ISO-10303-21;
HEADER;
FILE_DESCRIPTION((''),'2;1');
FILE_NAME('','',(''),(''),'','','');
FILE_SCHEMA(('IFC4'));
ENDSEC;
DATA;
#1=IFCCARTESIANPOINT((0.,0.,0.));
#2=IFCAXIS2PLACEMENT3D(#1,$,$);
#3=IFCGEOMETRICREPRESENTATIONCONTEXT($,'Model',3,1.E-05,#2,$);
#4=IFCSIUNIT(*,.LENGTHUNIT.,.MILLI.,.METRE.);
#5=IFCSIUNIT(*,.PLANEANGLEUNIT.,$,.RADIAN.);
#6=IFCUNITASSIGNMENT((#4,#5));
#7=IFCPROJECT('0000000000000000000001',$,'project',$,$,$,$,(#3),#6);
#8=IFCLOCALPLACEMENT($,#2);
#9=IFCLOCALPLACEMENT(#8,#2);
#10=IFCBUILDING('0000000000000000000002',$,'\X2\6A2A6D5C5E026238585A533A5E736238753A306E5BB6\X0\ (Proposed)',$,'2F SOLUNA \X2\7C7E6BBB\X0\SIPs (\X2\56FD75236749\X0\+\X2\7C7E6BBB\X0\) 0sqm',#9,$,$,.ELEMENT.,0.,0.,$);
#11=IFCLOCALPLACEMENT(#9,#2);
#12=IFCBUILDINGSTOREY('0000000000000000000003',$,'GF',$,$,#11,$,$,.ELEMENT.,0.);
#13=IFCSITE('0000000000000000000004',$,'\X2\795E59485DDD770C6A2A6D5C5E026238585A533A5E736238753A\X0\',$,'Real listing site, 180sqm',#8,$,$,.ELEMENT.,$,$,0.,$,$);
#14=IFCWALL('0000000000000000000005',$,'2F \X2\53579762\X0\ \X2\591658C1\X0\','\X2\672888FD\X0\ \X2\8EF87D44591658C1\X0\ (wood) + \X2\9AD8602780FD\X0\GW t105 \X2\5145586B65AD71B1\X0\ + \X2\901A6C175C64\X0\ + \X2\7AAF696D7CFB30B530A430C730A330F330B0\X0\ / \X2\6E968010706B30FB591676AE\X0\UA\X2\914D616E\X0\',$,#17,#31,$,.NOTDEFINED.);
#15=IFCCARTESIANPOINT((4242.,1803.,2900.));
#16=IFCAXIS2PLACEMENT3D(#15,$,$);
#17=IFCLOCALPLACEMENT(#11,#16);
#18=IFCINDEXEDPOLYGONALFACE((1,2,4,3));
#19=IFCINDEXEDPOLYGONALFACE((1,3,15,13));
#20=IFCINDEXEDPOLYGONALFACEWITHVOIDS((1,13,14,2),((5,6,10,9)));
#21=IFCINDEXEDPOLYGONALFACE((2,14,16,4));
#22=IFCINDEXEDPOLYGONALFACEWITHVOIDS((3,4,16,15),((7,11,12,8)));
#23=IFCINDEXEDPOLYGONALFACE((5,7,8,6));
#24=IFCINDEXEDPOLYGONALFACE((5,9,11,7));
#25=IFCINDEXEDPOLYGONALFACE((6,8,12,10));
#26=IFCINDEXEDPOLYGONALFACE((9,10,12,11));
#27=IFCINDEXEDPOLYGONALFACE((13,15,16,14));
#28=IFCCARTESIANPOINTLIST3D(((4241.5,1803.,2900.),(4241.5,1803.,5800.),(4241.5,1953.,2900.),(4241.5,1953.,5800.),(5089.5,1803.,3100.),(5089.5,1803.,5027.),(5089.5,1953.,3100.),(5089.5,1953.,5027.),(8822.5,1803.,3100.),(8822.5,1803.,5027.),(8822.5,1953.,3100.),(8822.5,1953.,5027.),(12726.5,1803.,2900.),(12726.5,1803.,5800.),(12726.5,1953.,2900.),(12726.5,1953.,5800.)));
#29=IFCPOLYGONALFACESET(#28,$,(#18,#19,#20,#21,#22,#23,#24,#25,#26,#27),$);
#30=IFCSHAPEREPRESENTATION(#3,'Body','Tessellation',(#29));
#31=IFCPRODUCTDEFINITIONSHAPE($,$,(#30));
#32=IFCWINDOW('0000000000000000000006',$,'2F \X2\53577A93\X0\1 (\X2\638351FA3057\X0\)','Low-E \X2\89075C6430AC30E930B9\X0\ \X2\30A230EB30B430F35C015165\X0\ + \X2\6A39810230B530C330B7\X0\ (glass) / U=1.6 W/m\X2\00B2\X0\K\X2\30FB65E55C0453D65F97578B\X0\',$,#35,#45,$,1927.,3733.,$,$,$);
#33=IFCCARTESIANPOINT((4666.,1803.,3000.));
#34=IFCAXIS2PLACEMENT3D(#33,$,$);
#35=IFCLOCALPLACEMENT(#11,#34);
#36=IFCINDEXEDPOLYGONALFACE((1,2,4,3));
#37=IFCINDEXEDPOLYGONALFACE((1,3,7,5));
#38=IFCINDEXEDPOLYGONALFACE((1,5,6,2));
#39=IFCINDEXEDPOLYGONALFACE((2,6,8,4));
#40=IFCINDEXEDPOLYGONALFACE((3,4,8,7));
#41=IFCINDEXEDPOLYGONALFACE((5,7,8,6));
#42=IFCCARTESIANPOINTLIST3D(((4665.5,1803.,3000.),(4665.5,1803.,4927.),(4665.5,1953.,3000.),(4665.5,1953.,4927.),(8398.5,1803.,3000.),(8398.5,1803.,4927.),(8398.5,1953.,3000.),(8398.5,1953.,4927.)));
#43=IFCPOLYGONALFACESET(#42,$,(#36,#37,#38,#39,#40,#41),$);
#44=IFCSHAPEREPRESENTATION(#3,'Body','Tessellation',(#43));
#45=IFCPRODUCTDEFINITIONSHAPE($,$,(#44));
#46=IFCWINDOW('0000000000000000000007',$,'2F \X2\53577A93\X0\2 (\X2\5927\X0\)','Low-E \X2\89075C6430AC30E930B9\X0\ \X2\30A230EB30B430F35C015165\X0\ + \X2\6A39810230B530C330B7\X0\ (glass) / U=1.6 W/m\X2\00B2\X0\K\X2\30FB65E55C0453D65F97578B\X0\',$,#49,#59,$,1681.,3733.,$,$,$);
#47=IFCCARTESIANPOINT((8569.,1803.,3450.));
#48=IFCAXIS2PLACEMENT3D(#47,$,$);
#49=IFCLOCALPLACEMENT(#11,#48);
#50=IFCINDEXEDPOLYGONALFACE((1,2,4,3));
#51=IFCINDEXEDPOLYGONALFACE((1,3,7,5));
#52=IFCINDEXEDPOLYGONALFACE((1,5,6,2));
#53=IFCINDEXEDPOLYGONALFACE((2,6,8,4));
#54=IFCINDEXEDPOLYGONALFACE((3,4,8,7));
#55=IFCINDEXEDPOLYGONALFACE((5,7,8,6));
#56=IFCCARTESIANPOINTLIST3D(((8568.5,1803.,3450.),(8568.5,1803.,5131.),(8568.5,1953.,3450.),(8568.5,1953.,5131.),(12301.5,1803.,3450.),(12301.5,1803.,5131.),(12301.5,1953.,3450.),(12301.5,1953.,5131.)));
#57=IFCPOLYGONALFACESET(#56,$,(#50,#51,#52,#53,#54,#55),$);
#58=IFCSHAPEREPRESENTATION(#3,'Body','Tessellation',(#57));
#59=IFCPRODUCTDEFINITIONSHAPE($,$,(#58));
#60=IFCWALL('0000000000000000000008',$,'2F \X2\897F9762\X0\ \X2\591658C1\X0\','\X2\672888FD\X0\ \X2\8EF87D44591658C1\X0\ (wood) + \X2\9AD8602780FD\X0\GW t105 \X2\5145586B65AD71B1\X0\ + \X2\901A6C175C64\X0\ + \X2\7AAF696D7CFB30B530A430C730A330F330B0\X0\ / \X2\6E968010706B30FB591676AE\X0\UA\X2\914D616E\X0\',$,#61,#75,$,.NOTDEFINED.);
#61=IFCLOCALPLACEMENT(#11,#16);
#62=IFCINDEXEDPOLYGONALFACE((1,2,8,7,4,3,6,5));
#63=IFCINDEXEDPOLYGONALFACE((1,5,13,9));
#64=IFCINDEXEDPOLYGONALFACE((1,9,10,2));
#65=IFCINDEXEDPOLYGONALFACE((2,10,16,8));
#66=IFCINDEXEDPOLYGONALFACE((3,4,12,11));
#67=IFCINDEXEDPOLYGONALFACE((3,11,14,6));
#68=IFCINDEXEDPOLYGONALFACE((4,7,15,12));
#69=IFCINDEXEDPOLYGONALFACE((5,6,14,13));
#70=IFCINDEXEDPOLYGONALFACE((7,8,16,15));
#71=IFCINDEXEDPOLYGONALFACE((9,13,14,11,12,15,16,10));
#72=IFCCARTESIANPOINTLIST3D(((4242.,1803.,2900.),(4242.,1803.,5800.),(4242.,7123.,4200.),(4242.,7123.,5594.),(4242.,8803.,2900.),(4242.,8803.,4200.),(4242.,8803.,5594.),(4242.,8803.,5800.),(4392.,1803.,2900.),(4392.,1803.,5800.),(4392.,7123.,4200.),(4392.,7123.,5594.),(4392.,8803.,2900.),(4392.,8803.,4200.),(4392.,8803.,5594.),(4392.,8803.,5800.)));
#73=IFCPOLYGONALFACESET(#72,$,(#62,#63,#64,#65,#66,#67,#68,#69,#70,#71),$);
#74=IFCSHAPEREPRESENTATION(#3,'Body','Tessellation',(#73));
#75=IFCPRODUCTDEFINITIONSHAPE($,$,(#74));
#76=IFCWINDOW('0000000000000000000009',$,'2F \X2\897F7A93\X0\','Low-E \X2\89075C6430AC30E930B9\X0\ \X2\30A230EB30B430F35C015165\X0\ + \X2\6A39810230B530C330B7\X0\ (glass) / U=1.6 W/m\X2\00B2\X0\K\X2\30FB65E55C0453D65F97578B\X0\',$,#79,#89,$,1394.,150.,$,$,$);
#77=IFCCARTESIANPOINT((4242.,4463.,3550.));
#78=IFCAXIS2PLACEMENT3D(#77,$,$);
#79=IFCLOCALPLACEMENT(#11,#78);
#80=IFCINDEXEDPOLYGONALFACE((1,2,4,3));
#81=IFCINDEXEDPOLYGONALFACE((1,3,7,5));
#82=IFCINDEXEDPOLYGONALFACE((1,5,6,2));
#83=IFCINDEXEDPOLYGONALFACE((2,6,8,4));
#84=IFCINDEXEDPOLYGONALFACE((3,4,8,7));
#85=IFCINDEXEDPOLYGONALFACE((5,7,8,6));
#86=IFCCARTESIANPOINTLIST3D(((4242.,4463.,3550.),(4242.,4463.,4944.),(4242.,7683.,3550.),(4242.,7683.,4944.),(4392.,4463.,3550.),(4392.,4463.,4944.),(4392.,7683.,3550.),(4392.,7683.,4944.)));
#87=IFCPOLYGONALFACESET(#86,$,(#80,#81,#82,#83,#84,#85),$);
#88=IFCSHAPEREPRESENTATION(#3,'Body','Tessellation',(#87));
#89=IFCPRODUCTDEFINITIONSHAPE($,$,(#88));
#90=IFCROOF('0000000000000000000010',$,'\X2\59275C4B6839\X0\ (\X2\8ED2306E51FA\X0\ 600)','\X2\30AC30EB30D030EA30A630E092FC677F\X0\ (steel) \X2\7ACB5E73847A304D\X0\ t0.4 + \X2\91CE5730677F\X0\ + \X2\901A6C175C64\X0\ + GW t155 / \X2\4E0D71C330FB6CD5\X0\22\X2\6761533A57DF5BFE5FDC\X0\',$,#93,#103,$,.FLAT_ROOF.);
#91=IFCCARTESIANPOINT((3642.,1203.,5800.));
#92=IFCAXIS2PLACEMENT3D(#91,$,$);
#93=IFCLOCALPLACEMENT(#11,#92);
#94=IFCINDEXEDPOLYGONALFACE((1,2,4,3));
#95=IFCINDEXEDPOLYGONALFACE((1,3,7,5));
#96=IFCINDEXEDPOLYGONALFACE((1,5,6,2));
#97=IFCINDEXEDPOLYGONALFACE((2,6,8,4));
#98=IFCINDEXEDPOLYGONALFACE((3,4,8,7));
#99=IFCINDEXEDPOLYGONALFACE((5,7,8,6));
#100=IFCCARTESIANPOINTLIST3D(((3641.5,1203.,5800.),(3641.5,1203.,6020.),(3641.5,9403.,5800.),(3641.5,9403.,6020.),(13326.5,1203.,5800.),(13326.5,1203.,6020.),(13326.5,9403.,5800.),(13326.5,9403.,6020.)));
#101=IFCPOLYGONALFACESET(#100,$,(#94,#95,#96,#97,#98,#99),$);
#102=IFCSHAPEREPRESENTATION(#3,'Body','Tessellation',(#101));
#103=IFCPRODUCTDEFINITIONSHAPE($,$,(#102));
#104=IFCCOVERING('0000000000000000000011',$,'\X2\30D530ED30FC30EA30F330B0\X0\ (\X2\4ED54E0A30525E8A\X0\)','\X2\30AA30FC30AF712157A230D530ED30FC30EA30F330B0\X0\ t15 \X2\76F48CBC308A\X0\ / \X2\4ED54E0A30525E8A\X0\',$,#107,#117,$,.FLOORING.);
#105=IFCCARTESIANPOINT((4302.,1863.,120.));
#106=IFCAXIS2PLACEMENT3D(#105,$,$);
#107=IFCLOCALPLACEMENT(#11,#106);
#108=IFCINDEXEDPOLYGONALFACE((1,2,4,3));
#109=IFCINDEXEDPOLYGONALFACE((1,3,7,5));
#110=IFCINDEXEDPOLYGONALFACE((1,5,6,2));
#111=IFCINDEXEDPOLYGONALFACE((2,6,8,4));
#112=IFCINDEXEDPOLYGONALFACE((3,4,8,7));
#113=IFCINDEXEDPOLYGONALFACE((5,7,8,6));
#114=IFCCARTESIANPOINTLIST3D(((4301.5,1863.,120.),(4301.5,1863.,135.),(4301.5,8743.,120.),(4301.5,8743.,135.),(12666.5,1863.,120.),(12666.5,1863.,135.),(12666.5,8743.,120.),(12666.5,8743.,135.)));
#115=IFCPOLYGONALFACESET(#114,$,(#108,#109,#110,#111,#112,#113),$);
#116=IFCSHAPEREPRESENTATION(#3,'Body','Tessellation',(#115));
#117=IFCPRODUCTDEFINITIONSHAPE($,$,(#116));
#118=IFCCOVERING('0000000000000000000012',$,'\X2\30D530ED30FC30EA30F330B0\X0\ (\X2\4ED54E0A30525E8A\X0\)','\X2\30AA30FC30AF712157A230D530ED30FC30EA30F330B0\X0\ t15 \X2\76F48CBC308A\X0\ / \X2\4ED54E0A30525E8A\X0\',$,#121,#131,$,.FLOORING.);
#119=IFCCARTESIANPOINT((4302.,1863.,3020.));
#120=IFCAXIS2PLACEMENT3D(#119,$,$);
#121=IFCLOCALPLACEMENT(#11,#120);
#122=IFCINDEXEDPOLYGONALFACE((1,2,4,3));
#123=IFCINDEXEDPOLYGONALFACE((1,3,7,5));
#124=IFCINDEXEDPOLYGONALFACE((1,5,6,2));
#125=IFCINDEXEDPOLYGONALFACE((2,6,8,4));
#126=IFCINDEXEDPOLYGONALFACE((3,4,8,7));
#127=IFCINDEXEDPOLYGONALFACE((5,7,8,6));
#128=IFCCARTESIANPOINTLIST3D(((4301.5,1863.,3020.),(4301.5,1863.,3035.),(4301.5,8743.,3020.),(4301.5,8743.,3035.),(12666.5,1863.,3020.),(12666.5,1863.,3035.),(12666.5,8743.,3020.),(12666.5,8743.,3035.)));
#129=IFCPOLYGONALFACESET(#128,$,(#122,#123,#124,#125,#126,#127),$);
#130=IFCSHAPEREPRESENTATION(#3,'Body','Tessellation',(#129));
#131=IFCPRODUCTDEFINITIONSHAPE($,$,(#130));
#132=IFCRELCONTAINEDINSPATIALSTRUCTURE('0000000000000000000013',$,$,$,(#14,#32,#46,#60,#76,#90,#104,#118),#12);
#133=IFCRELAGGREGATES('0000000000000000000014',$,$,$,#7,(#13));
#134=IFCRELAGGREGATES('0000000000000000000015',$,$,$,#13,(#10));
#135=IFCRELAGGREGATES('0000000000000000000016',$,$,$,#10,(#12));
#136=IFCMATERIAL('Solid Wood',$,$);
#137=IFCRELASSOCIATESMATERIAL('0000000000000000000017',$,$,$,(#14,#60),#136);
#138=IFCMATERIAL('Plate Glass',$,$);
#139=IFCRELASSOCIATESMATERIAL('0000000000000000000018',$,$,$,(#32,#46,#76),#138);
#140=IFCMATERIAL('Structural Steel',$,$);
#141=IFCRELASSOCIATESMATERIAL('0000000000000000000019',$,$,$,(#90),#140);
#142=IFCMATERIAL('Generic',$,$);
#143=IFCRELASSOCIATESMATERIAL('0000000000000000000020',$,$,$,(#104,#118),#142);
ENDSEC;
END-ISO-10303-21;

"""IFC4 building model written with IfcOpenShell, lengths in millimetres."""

from ifc_helpers import new_model, si_unit, frame, frame_2d, origin, place, context, project, spatial, rectangle, extrude, material, element, fill, save


model = new_model("IFC4")

# Units and contexts
model_context = context("Model", 3, precision=1e-05, world=origin())
ifc_project = project(units=[si_unit("LENGTHUNIT", "METRE", prefix="MILLI"), si_unit("PLANEANGLEUNIT", "RADIAN")], contexts=[model_context])

# Site, building, storey
site_placement = place(None, origin())
site = spatial("IfcSite", under=ifc_project, at=site_placement, Name="神奈川県横浜市戸塚区平戸町", ObjectType="Real listing site, 180sqm", CompositionType="ELEMENT", RefElevation=0.0)
building_placement = place(site_placement, origin())
building = spatial("IfcBuilding", under=site, at=building_placement, Name="横浜市戸塚区平戸町の家 (Proposed)", ObjectType="2F SOLUNA 籾殻SIPs (国産杉+籾殻) 0sqm", CompositionType="ELEMENT", ElevationOfRefHeight=0.0, ElevationOfTerrain=0.0)
storey_placement = place(building_placement, origin())
storey = spatial("IfcBuildingStorey", under=building, at=storey_placement, Name="GF", CompositionType="ELEMENT", Elevation=0.0)

# Shared definitions
ifc_material_1 = material(Name="Solid Wood")

# Shared definitions
ifc_material_2 = material(Name="Plate Glass")

# Wall, openings, windows
wall_1_placement = place(storey_placement, frame((4242.0, 1803.0, 2900.0)))
wall_1 = element("IfcWall", 1, at=wall_1_placement, inside=storey, material=ifc_material_1, Name="2F 南面 外壁", Description="木製 軸組外壁 (wood) + 高性能GW t105 充填断熱 + 通気層 + 窯業系サイディング / 準耐火・外皮UA配慮", PredefinedType="NOTDEFINED", context=model_context, shape_type="SweptSolid", body=[
    extrude(rectangle(XDim=8485.0, YDim=150.0, at=frame_2d((4242.0, 75.0))), frame((4242.0, 1803.0, 2900.0)), (0.0, 0.0, 1.0), 2900.0),
])
opening_1_placement = place(storey_placement, frame((4666.0, 1803.0, 3000.0)))
opening_1 = element("IfcOpeningElement", 2, at=opening_1_placement, cuts=wall_1, PredefinedType="NOTDEFINED", context=model_context, shape_type="SweptSolid", body=[
    extrude(rectangle(XDim=3733.0, YDim=150.0, at=frame_2d((1866.0, 75.0))), frame((4666.0, 1803.0, 3000.0)), (0.0, 0.0, 1.0), 1927.0),
])
opening_2_placement = place(storey_placement, frame((8569.0, 1803.0, 3450.0)))
opening_2 = element("IfcOpeningElement", 3, at=opening_2_placement, cuts=wall_1, PredefinedType="NOTDEFINED", context=model_context, shape_type="SweptSolid", body=[
    extrude(rectangle(XDim=3733.0, YDim=150.0, at=frame_2d((1866.0, 75.0))), frame((8569.0, 1803.0, 3450.0)), (0.0, 0.0, 1.0), 1681.0),
])
window_1_placement = place(storey_placement, frame((4666.0, 1803.0, 3000.0)))
window_1 = element("IfcWindow", 4, at=window_1_placement, inside=storey, material=ifc_material_2, Name="2F 南窓1 (掃出し)", Description="Low-E 複層ガラス アルゴン封入 + 樹脂サッシ (glass) / U=1.6 W/m²K・日射取得型", OverallHeight=1927.0, OverallWidth=3733.0, context=model_context, shape_type="SweptSolid", body=[
    extrude(rectangle(XDim=3733.0, YDim=150.0, at=frame_2d((1866.0, 75.0))), frame((4666.0, 1803.0, 3000.0)), (0.0, 0.0, 1.0), 1927.0),
])
fill(opening_1, window_1)
window_2_placement = place(storey_placement, frame((8569.0, 1803.0, 3450.0)))
window_2 = element("IfcWindow", 5, at=window_2_placement, inside=storey, material=ifc_material_2, Name="2F 南窓2 (大)", Description="Low-E 複層ガラス アルゴン封入 + 樹脂サッシ (glass) / U=1.6 W/m²K・日射取得型", OverallHeight=1681.0, OverallWidth=3733.0, context=model_context, shape_type="SweptSolid", body=[
    extrude(rectangle(XDim=3733.0, YDim=150.0, at=frame_2d((1866.0, 75.0))), frame((8569.0, 1803.0, 3450.0)), (0.0, 0.0, 1.0), 1681.0),
])
fill(opening_2, window_2)

# Wall, opening, window
wall_2_placement = place(storey_placement, frame((4242.0, 1803.0, 2900.0)))
wall_2 = element("IfcWall", 6, at=wall_2_placement, inside=storey, material=ifc_material_1, Name="2F 西面 外壁", Description="木製 軸組外壁 (wood) + 高性能GW t105 充填断熱 + 通気層 + 窯業系サイディング / 準耐火・外皮UA配慮", PredefinedType="NOTDEFINED", context=model_context, shape_type="SweptSolid", body=[
    extrude(rectangle(XDim=150.0, YDim=7000.0, at=frame_2d((75.0, 3500.0))), frame((4242.0, 1803.0, 2900.0)), (0.0, 0.0, 1.0), 2900.0),
])
opening_3_placement = place(storey_placement, frame((4242.0, 4463.0, 3550.0)))
opening_3 = element("IfcOpeningElement", 7, at=opening_3_placement, cuts=wall_2, PredefinedType="NOTDEFINED", context=model_context, shape_type="SweptSolid", body=[
    extrude(rectangle(XDim=150.0, YDim=3220.0, at=frame_2d((75.0, 1610.0))), frame((4242.0, 4463.0, 3550.0)), (0.0, 0.0, 1.0), 1394.0),
])
window_3_placement = place(storey_placement, frame((4242.0, 4463.0, 3550.0)))
window_3 = element("IfcWindow", 8, at=window_3_placement, inside=storey, material=ifc_material_2, Name="2F 西窓", Description="Low-E 複層ガラス アルゴン封入 + 樹脂サッシ (glass) / U=1.6 W/m²K・日射取得型", OverallHeight=1394.0, OverallWidth=150.0, context=model_context, shape_type="SweptSolid", body=[
    extrude(rectangle(XDim=150.0, YDim=3220.0, at=frame_2d((75.0, 1610.0))), frame((4242.0, 4463.0, 3550.0)), (0.0, 0.0, 1.0), 1394.0),
])
fill(opening_3, window_3)

# Roof
ifc_material_3 = material(Name="Structural Steel")
roof_placement = place(storey_placement, frame((3642.0, 1203.0, 5800.0)))
element("IfcRoof", 9, at=roof_placement, inside=storey, material=ifc_material_3, Name="大屋根 (軒の出 600)", Description="ガルバリウム鋼板 (steel) 立平葺き t0.4 + 野地板 + 通気層 + GW t155 / 不燃・法22条区域対応", PredefinedType="FLAT_ROOF", context=model_context, shape_type="SweptSolid", body=[
    extrude(rectangle(XDim=9685.0, YDim=8200.0, at=frame_2d((4842.0, 4100.0))), frame((3642.0, 1203.0, 5800.0)), (0.0, 0.0, 1.0), 220.0),
])

# Coverings
ifc_material_4 = material(Name="Generic")
covering_1_placement = place(storey_placement, frame((4302.0, 1863.0, 120.0)))
element("IfcCovering", 10, at=covering_1_placement, inside=storey, material=ifc_material_4, Name="フローリング (仕上げ床)", Description="オーク無垢フローリング t15 直貼り / 仕上げ床", PredefinedType="FLOORING", context=model_context, shape_type="SweptSolid", body=[
    extrude(rectangle(XDim=8365.0, YDim=6880.0, at=frame_2d((4182.0, 3440.0))), frame((4302.0, 1863.0, 120.0)), (0.0, 0.0, 1.0), 15.0),
])
covering_2_placement = place(storey_placement, frame((4302.0, 1863.0, 3020.0)))
element("IfcCovering", 11, at=covering_2_placement, inside=storey, material=ifc_material_4, Name="フローリング (仕上げ床)", Description="オーク無垢フローリング t15 直貼り / 仕上げ床", PredefinedType="FLOORING", context=model_context, shape_type="SweptSolid", body=[
    extrude(rectangle(XDim=8365.0, YDim=6880.0, at=frame_2d((4182.0, 3440.0))), frame((4302.0, 1863.0, 3020.0)), (0.0, 0.0, 1.0), 15.0),
])

save(model, "model.ifc")
